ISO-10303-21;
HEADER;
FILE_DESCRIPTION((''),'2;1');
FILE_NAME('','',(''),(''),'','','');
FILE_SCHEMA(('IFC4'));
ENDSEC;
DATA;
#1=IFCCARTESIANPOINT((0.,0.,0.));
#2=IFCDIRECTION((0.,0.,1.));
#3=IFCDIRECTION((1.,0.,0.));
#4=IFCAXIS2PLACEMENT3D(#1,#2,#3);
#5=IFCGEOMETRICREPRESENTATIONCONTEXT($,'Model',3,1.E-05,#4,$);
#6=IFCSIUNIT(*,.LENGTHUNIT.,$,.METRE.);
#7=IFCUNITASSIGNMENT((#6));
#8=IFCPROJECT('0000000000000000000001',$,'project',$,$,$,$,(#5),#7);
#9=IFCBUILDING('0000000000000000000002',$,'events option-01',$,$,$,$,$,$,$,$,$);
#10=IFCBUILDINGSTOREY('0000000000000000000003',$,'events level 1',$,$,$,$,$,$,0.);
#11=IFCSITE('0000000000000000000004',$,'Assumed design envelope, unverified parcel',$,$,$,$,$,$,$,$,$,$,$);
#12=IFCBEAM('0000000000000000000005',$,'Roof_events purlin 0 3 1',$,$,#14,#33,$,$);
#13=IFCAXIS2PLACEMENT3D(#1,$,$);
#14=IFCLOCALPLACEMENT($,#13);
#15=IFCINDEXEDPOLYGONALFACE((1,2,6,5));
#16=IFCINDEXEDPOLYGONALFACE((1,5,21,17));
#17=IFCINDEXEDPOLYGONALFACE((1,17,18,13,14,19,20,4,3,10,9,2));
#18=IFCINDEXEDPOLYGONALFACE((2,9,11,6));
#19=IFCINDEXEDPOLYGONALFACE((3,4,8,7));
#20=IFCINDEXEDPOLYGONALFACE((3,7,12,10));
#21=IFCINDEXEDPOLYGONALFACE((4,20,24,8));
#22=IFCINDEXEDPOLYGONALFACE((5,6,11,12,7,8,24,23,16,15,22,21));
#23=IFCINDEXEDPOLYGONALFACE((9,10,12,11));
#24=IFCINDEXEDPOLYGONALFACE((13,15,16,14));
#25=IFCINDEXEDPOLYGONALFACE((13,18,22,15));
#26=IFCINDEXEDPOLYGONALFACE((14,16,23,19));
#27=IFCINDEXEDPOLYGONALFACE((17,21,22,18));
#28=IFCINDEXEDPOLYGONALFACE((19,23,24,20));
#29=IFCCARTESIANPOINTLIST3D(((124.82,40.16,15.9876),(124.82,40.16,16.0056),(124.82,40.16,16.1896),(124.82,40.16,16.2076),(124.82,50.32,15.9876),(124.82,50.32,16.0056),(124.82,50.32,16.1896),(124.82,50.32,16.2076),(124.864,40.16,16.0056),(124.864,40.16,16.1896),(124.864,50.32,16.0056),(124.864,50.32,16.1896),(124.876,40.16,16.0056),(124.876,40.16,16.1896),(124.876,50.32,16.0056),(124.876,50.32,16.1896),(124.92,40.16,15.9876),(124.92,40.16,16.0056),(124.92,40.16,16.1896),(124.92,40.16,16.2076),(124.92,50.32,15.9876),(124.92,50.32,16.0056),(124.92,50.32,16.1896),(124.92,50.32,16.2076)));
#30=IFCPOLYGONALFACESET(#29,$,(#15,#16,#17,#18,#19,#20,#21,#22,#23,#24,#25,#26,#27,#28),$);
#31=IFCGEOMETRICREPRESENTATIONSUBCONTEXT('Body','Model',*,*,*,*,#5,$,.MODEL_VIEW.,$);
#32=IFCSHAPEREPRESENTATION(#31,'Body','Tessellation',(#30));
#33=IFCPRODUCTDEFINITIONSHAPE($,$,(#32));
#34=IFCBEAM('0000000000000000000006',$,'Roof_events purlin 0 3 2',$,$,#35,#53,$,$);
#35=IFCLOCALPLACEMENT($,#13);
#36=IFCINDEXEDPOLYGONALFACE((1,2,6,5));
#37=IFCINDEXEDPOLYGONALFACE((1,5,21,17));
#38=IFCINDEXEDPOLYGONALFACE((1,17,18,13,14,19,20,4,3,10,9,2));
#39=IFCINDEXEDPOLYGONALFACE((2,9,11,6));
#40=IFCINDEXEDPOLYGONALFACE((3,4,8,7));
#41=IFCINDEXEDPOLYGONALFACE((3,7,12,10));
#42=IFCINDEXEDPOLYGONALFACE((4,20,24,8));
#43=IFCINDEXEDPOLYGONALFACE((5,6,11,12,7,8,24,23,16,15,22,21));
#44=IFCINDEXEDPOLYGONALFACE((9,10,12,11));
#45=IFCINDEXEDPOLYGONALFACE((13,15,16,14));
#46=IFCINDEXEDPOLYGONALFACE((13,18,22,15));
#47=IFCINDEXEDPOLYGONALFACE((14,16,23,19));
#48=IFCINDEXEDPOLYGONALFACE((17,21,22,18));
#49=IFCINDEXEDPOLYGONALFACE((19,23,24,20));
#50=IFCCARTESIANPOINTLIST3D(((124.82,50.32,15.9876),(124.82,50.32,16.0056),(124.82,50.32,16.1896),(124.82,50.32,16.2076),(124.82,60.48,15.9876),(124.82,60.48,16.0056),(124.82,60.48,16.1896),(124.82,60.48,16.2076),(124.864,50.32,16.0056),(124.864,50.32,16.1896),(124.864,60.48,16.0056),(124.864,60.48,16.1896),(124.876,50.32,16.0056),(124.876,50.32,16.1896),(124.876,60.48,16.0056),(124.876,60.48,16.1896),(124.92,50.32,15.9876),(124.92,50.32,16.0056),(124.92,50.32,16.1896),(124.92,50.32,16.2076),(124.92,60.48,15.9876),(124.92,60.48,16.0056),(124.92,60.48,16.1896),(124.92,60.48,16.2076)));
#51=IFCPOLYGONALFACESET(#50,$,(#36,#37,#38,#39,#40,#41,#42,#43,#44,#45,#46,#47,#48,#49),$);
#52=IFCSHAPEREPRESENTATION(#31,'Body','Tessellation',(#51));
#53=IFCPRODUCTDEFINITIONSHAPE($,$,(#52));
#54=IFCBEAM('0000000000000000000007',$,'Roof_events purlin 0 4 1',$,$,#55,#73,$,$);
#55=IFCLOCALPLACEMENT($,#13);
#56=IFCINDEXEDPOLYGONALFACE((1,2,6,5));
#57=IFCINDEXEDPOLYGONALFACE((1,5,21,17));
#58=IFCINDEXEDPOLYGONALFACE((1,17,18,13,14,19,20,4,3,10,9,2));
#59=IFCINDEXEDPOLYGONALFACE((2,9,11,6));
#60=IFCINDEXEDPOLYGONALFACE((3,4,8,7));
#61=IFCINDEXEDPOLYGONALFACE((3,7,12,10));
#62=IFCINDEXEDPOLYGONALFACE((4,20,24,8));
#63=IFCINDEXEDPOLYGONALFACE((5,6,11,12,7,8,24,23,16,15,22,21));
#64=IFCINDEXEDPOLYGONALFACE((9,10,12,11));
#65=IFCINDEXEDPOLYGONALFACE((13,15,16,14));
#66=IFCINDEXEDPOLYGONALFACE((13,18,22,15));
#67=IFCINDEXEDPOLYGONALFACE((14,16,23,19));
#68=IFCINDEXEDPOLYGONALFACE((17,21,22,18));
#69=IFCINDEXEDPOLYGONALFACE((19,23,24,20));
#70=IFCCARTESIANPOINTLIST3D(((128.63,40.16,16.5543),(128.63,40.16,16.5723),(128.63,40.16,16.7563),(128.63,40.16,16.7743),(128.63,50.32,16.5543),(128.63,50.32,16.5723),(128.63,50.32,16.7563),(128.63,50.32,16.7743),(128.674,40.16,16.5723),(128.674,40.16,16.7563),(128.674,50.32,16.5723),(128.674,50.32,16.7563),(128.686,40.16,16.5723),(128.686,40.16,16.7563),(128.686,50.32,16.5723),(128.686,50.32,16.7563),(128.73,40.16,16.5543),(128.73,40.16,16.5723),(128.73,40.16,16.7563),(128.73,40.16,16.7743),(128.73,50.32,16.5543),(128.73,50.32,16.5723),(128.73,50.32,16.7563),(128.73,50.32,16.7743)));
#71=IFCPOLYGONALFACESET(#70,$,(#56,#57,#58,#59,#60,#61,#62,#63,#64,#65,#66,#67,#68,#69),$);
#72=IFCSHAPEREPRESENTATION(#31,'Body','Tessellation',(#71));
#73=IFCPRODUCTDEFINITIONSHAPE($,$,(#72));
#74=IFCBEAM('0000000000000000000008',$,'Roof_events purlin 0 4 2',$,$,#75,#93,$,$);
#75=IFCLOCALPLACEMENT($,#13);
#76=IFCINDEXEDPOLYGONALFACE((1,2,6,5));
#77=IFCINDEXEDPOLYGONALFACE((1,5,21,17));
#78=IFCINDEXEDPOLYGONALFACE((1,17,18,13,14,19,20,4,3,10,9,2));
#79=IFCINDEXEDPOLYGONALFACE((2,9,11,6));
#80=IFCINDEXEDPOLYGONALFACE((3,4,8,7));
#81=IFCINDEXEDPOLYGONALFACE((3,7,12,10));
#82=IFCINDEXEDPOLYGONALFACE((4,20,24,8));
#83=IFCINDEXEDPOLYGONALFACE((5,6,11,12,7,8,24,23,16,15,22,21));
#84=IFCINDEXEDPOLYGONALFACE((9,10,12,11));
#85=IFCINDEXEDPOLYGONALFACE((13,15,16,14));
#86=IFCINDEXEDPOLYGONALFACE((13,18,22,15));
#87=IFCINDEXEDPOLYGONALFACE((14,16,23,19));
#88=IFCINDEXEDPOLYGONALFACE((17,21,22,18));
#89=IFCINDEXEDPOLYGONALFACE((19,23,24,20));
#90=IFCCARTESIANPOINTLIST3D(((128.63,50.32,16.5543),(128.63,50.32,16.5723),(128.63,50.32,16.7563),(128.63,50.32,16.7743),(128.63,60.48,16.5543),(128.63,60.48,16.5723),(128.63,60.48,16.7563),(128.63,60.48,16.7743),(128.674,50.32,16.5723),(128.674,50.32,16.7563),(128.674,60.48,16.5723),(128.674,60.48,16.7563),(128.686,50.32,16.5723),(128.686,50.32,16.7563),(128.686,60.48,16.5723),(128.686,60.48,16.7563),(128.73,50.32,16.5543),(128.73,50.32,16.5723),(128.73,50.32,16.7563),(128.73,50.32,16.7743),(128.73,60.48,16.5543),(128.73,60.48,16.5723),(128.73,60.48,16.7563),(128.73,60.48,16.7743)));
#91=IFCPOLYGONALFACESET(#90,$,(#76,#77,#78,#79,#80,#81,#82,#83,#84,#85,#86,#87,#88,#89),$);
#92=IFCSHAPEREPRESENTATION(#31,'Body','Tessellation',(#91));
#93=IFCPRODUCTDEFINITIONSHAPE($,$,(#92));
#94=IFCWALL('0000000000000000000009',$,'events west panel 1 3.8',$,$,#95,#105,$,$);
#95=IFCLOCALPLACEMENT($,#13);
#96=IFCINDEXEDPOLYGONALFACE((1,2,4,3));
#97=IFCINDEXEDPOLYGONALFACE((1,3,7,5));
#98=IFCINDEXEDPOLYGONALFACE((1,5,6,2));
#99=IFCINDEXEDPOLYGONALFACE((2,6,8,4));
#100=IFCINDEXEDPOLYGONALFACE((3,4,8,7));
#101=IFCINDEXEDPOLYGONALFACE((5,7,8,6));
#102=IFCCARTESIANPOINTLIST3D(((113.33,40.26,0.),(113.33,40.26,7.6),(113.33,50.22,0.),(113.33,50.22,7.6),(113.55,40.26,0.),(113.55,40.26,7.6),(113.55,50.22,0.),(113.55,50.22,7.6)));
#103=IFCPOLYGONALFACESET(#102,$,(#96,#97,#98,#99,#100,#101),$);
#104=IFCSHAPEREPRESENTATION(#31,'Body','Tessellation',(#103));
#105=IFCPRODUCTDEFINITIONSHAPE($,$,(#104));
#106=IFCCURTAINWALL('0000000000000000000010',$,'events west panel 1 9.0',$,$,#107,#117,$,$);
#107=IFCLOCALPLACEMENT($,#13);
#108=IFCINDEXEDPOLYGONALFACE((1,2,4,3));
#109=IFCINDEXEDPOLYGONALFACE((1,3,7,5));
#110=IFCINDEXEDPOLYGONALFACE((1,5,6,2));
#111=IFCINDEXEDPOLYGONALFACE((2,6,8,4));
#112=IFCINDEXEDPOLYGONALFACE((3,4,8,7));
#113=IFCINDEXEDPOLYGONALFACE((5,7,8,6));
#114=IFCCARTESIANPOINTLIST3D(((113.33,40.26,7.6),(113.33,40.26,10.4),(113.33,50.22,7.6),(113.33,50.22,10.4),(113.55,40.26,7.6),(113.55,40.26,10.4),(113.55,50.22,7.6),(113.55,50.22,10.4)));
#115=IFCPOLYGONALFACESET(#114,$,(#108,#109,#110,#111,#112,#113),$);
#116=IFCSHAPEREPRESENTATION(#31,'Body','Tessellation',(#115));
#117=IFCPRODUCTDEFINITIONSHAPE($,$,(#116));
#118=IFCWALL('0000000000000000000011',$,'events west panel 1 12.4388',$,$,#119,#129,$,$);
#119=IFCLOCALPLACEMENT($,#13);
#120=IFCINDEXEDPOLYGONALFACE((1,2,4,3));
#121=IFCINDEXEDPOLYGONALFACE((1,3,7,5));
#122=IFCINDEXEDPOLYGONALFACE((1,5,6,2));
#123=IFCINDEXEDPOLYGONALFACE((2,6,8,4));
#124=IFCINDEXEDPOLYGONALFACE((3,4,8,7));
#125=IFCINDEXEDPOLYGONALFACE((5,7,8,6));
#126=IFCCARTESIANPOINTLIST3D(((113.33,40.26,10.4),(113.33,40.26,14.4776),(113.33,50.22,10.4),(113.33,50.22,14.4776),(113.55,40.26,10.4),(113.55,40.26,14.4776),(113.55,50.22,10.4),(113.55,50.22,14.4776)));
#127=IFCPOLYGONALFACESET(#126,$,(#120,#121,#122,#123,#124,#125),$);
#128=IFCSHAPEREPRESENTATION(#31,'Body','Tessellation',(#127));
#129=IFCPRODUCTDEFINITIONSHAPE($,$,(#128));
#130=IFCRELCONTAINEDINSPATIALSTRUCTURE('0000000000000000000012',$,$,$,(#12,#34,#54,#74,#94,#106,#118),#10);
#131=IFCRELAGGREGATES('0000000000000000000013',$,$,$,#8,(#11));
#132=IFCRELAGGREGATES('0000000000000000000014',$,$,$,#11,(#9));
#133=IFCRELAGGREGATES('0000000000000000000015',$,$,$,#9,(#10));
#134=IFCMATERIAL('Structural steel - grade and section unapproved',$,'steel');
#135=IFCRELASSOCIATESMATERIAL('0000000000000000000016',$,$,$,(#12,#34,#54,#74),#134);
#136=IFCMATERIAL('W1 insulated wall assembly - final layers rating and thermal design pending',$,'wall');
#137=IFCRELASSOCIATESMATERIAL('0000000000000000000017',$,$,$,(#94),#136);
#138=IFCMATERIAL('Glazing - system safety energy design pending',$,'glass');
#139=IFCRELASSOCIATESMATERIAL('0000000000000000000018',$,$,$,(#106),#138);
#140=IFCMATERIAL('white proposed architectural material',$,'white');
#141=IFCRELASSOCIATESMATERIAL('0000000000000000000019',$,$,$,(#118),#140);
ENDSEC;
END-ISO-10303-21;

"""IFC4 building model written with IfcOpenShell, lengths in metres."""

from ifc_helpers import new_model, si_unit, frame, origin_with_axes, place, context, subcontext, project, spatial, rectangle, i_section, extrude, material, element, save


model = new_model("IFC4")

# Units and contexts
model_context = context("Model", 3, precision=1e-05, world=origin_with_axes())
body_context = subcontext(model_context, "Body", "Model", "MODEL_VIEW")
ifc_project = project(units=[si_unit("LENGTHUNIT", "METRE")], contexts=[model_context])

# Site, building, storey
site = spatial("IfcSite", under=ifc_project, Name="Assumed design envelope, unverified parcel")
building = spatial("IfcBuilding", under=site, Name="events option-01")
storey = spatial("IfcBuildingStorey", under=building, Name="events level 1", Elevation=0.0)

# Shared definitions
ifc_material_1 = material(Name="Structural steel - grade and section unapproved", Category="steel")

# Beams
for number, where, z_axis, x_axis, name in (
    (1, (124.87, 40.16, 16.0976), (0.0, 1.0, 0.0), (-1.0, 0.0, 0.0), "Roof_events purlin 0 3 1"),
    (2, (124.87, 50.32, 16.0976), (0.0, 1.0, 0.0), (-1.0, 0.0, 0.0), "Roof_events purlin 0 3 2"),
    (3, (128.68, 40.16, 16.6643), (0.0, 1.0, 0.0), (-1.0, 0.0, 0.0), "Roof_events purlin 0 4 1"),
    (4, (128.68, 50.32, 16.6643), (0.0, 1.0, 0.0), (-1.0, 0.0, 0.0), "Roof_events purlin 0 4 2"),
):
    element("IfcBeam", number, at=place(None, frame(where, z_axis=z_axis, x_axis=x_axis)), inside=storey, material=ifc_material_1, Name=name, context=body_context, shape_type="SweptSolid", body=[
        extrude(i_section(OverallWidth=0.1, OverallDepth=0.22, WebThickness=0.012, FlangeThickness=0.018, FilletRadius=0.0), origin_with_axes(), (0.0, 0.0, 1.0), 10.16),
    ])

# Wall
ifc_material_2 = material(Name="W1 insulated wall assembly - final layers rating and thermal design pending", Category="wall")
wall_1_placement = place(None, frame((113.44, 45.24, 0.0), z_axis=(0.0, 0.0, 1.0), x_axis=(1.0, 0.0, 0.0)))
element("IfcWall", 5, at=wall_1_placement, inside=storey, material=ifc_material_2, Name="events west panel 1 3.8", context=body_context, shape_type="SweptSolid", body=[
    extrude(rectangle(XDim=0.22, YDim=9.96), origin_with_axes(), (0.0, 0.0, 1.0), 7.6),
])

# Curtain wall
ifc_material_3 = material(Name="Glazing - system safety energy design pending", Category="glass")
curtain_wall_placement = place(None, frame((113.44, 45.24, 7.6), z_axis=(0.0, 0.0, 1.0), x_axis=(1.0, 0.0, 0.0)))
element("IfcCurtainWall", 6, at=curtain_wall_placement, inside=storey, material=ifc_material_3, Name="events west panel 1 9.0", context=body_context, shape_type="SweptSolid", body=[
    extrude(rectangle(XDim=0.22, YDim=9.96), origin_with_axes(), (0.0, 0.0, 1.0), 2.8),
])

# Wall
ifc_material_4 = material(Name="white proposed architectural material", Category="white")
wall_2_placement = place(None, frame((113.44, 45.24, 10.4), z_axis=(0.0, 0.0, 1.0), x_axis=(1.0, 0.0, 0.0)))
element("IfcWall", 7, at=wall_2_placement, inside=storey, material=ifc_material_4, Name="events west panel 1 12.4388", context=body_context, shape_type="SweptSolid", body=[
    extrude(rectangle(XDim=0.22, YDim=9.96), origin_with_axes(), (0.0, 0.0, 1.0), 4.0776),
])

save(model, "model.ifc")
